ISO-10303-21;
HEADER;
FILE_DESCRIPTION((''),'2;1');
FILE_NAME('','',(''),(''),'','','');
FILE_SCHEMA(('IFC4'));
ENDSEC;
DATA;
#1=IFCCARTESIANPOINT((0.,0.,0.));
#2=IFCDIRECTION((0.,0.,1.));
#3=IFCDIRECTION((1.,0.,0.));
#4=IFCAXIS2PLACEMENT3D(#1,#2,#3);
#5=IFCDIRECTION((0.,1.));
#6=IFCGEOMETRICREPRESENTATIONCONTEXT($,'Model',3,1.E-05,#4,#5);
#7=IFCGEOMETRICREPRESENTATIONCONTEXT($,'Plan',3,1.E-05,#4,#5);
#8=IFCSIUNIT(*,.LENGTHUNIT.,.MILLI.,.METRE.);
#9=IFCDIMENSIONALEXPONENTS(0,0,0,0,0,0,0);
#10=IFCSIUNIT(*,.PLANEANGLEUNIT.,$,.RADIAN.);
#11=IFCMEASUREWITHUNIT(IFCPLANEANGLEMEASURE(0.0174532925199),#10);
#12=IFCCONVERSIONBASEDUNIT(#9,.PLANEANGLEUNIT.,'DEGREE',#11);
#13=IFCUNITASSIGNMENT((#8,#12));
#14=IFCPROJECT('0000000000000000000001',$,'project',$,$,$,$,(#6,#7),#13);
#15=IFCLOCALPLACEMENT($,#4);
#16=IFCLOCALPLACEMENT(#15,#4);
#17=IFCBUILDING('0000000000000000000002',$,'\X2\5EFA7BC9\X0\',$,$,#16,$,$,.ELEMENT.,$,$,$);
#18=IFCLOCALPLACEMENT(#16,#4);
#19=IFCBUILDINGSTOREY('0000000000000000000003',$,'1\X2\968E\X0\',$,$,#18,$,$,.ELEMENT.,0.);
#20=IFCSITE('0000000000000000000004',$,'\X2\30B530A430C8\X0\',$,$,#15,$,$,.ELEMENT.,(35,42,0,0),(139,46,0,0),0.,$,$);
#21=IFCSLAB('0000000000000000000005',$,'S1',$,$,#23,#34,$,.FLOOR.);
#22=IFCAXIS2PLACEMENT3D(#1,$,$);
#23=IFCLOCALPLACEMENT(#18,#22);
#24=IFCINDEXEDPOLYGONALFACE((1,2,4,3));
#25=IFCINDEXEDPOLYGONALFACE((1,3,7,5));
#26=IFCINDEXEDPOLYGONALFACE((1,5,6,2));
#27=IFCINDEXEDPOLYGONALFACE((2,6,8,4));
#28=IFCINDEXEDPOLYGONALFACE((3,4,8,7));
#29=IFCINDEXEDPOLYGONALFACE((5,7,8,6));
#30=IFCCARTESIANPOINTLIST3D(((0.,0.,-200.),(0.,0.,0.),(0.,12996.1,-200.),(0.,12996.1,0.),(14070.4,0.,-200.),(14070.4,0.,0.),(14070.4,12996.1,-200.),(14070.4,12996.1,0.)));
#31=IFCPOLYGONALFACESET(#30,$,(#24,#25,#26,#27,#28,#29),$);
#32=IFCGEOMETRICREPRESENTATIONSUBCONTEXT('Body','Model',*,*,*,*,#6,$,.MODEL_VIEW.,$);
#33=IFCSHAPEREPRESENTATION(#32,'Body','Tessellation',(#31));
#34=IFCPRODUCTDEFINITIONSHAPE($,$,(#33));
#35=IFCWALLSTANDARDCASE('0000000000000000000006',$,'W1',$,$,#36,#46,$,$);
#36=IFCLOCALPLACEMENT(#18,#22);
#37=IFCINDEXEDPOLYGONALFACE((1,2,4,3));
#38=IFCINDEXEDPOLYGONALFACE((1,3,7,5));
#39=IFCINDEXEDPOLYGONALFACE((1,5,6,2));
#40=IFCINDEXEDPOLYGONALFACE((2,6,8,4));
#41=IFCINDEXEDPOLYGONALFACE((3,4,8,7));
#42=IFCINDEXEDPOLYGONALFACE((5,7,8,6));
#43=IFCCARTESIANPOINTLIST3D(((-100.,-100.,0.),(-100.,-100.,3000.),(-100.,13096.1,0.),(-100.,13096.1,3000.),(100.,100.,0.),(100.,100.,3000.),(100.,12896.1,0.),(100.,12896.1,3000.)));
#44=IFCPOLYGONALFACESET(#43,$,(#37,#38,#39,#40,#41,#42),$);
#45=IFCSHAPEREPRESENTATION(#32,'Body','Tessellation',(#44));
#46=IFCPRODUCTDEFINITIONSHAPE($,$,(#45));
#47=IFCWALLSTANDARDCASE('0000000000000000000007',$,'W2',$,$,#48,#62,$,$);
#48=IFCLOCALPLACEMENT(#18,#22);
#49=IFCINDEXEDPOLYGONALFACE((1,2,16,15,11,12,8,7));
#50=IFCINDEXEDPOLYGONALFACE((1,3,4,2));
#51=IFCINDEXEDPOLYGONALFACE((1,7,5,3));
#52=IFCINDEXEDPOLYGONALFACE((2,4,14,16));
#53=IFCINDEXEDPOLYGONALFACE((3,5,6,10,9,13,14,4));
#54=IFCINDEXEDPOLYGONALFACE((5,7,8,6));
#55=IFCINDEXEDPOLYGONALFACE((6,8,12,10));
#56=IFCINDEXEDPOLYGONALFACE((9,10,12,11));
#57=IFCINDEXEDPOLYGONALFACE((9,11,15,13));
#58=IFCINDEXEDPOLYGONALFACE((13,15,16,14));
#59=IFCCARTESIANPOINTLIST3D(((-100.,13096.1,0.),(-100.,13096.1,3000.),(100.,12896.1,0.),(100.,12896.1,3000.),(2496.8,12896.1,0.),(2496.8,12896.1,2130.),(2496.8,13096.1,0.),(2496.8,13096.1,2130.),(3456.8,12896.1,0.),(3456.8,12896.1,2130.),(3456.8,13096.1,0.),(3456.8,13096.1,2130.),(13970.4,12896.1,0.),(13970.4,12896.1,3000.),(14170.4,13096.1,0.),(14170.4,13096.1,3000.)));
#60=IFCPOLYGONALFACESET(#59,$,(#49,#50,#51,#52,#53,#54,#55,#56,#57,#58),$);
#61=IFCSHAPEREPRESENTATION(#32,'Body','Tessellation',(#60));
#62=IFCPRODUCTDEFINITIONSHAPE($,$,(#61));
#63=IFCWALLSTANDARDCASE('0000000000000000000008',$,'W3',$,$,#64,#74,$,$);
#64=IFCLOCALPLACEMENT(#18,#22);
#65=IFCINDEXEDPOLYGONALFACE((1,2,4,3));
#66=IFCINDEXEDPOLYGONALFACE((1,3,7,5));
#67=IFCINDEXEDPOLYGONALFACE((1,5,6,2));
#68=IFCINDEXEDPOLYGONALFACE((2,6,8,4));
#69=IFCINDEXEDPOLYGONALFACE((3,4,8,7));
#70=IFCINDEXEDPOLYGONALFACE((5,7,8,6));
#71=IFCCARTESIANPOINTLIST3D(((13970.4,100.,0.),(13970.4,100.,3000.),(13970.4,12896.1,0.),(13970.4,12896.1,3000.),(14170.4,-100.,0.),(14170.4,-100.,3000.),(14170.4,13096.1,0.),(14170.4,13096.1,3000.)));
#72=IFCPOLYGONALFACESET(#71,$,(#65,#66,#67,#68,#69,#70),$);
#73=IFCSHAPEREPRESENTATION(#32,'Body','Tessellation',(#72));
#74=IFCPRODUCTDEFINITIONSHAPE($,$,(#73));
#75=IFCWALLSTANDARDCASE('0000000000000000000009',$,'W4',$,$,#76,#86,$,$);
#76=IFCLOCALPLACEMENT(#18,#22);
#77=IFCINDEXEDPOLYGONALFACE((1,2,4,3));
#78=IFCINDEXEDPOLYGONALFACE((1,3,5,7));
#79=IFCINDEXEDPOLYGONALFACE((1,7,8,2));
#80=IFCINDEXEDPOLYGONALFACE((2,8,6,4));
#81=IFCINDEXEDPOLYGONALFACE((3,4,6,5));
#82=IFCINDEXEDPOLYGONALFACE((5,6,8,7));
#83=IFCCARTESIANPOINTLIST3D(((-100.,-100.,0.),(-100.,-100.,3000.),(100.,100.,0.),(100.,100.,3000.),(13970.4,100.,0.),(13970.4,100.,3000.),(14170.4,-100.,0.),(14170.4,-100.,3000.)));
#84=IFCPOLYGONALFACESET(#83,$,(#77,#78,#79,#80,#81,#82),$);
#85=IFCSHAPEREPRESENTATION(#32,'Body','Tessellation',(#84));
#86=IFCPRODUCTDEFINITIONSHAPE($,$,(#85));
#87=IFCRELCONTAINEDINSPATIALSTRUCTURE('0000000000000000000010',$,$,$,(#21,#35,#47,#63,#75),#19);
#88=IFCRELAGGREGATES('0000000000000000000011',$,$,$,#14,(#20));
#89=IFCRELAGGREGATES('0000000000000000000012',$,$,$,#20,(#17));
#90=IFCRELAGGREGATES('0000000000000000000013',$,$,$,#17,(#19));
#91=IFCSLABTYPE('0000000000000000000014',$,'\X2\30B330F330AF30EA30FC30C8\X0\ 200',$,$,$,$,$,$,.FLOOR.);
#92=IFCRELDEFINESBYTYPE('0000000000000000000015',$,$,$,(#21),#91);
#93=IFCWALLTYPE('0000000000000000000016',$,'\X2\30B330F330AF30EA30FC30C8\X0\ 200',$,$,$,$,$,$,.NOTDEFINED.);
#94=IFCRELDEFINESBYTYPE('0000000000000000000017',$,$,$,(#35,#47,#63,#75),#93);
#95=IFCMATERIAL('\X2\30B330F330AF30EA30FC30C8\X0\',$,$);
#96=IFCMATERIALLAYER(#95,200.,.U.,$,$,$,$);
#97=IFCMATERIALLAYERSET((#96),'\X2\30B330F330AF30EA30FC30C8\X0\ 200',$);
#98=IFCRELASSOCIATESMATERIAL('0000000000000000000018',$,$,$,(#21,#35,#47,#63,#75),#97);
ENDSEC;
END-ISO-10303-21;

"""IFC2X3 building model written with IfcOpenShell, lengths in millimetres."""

from ifc_helpers import new_model, entity, si_unit, converted_unit, direction, frame, origin_with_axes, origin_2d_with_axis, place, context, subcontext, project, spatial, polyline, rectangle, outline, extrude, material, layer, layer_set, layer_usage, type_object, element, save


model = new_model("IFC2X3")

# Units and contexts
model_context = context("Model", 3, precision=1e-05, world=origin_with_axes(), true_north=direction((0.0, 1.0)))
plan_context = context("Plan", 3, precision=1e-05, world=origin_with_axes(), true_north=direction((0.0, 1.0)))
body_context = subcontext(model_context, "Body", "Model", "MODEL_VIEW")
ifc_project = project(units=[si_unit("LENGTHUNIT", "METRE", prefix="MILLI"), converted_unit("PLANEANGLEUNIT", "DEGREE", entity("IfcPlaneAngleMeasure", 0.0174532925199), si_unit("PLANEANGLEUNIT", "RADIAN"), dimensions=[0, 0, 0, 0, 0, 0, 0])], contexts=[model_context, plan_context])

# Site, building, storey
site_placement = place(None, origin_with_axes())
site = spatial("IfcSite", under=ifc_project, at=site_placement, Name="サイト", CompositionType="ELEMENT", RefLatitude=(35, 42, 0, 0), RefLongitude=(139, 46, 0, 0), RefElevation=0.0)
building_placement = place(site_placement, origin_with_axes())
building = spatial("IfcBuilding", under=site, at=building_placement, Name="建築", CompositionType="ELEMENT")
storey_placement = place(building_placement, origin_with_axes())
storey = spatial("IfcBuildingStorey", under=building, at=storey_placement, Name="1階", CompositionType="ELEMENT", Elevation=0.0)

# Slab
ifc_material = material(Name="コンクリート")
ifc_layer = layer(ifc_material, 200.0, ventilated="UNKNOWN")
ifc_layer_set = layer_set([ifc_layer], Name="コンクリート 200")
ifc_layer_usage_1 = layer_usage(ifc_layer_set, "AXIS3", "NEGATIVE", 200.0)
slab_type = type_object("IfcSlabType", Name="コンクリート 200", PredefinedType="FLOOR")
slab_placement = place(storey_placement, frame((0.0, 12996.1, 0.0), z_axis=(0.0, 0.0, 1.0), x_axis=(1.0, 0.0, 0.0)))
element("IfcSlab", 1, at=slab_placement, inside=storey, type_object=slab_type, material=ifc_layer_usage_1, Name="S1", PredefinedType="FLOOR", context=body_context, shape_type="SweptSolid", body=[
    extrude(outline(polyline([(0.0, 0.0), (0.0, -12996.1), (14070.4, -12996.1), (14070.4, 0.0), (0.0, 0.0)])), frame((0.0, 0.0, -200.0), z_axis=(0.0, 0.0, 1.0), x_axis=(1.0, 0.0, 0.0)), (0.0, 0.0, 1.0), 200.0),
])

# Wall
ifc_layer_usage_2 = layer_usage(ifc_layer_set, "AXIS2", "POSITIVE", -100.0)
wall_type = type_object("IfcWallType", Name="コンクリート 200", PredefinedType="NOTDEFINED")
wall_1_placement = place(storey_placement, frame((0.0, 0.0, 0.0), z_axis=(0.0, 0.0, 1.0), x_axis=(0.0, 1.0, 0.0)))
element("IfcWallStandardCase", 2, at=wall_1_placement, inside=storey, type_object=wall_type, material=ifc_layer_usage_2, Name="W1", context=body_context, shape_type="SweptSolid", body=[
    extrude(outline(polyline([(100.0, -100.0), (12896.1, -100.0), (13096.1, 100.0), (-100.0, 100.0), (100.0, -100.0)])), origin_with_axes(), (0.0, 0.0, 1.0), 3000.0),
])

# Wall, opening
ifc_layer_usage_3 = layer_usage(ifc_layer_set, "AXIS2", "POSITIVE", -100.0)
wall_2_placement = place(storey_placement, frame((0.0, 12996.1, 0.0), z_axis=(0.0, 0.0, 1.0), x_axis=(1.0, 0.0, 0.0)))
wall_2 = element("IfcWallStandardCase", 3, at=wall_2_placement, inside=storey, type_object=wall_type, material=ifc_layer_usage_3, Name="W2", context=body_context, shape_type="SweptSolid", body=[
    extrude(outline(polyline([(100.0, -100.0), (13970.4, -100.0), (14170.4, 100.0), (-100.0, 100.0), (100.0, -100.0)])), origin_with_axes(), (0.0, 0.0, 1.0), 3000.0),
])
opening_placement = place(wall_2_placement, frame((2976.8, 0.0, 0.0), z_axis=(0.0, 0.0, 1.0), x_axis=(1.0, 0.0, 0.0)))
element("IfcOpeningElement", 4, at=opening_placement, cuts=wall_2, context=body_context, shape_type="SweptSolid", body=[
    extrude(rectangle(XDim=960.0, YDim=2130.0, at=origin_2d_with_axis()), frame((0.0, -200.0, 1065.0), z_axis=(0.0, 1.0, 0.0), x_axis=(1.0, 0.0, 0.0)), (0.0, 0.0, 1.0), 400.0),
])

# Walls
ifc_layer_usage_4 = layer_usage(ifc_layer_set, "AXIS2", "POSITIVE", -100.0)
wall_3_placement = place(storey_placement, frame((14070.4, 12996.1, 0.0), z_axis=(0.0, 0.0, 1.0), x_axis=(0.0, -1.0, 0.0)))
element("IfcWallStandardCase", 5, at=wall_3_placement, inside=storey, type_object=wall_type, material=ifc_layer_usage_4, Name="W3", context=body_context, shape_type="SweptSolid", body=[
    extrude(outline(polyline([(100.0, -100.0), (12896.1, -100.0), (13096.1, 100.0), (-100.0, 100.0), (100.0, -100.0)])), origin_with_axes(), (0.0, 0.0, 1.0), 3000.0),
])
ifc_layer_usage_5 = layer_usage(ifc_layer_set, "AXIS2", "POSITIVE", -100.0)
wall_4_placement = place(storey_placement, frame((14070.4, 0.0, 0.0), z_axis=(0.0, 0.0, 1.0), x_axis=(-1.0, 0.0, 0.0)))
element("IfcWallStandardCase", 6, at=wall_4_placement, inside=storey, type_object=wall_type, material=ifc_layer_usage_5, Name="W4", context=body_context, shape_type="SweptSolid", body=[
    extrude(outline(polyline([(100.0, -100.0), (13970.4, -100.0), (14170.4, 100.0), (-100.0, 100.0), (100.0, -100.0)])), origin_with_axes(), (0.0, 0.0, 1.0), 3000.0),
])

save(model, "model.ifc")
